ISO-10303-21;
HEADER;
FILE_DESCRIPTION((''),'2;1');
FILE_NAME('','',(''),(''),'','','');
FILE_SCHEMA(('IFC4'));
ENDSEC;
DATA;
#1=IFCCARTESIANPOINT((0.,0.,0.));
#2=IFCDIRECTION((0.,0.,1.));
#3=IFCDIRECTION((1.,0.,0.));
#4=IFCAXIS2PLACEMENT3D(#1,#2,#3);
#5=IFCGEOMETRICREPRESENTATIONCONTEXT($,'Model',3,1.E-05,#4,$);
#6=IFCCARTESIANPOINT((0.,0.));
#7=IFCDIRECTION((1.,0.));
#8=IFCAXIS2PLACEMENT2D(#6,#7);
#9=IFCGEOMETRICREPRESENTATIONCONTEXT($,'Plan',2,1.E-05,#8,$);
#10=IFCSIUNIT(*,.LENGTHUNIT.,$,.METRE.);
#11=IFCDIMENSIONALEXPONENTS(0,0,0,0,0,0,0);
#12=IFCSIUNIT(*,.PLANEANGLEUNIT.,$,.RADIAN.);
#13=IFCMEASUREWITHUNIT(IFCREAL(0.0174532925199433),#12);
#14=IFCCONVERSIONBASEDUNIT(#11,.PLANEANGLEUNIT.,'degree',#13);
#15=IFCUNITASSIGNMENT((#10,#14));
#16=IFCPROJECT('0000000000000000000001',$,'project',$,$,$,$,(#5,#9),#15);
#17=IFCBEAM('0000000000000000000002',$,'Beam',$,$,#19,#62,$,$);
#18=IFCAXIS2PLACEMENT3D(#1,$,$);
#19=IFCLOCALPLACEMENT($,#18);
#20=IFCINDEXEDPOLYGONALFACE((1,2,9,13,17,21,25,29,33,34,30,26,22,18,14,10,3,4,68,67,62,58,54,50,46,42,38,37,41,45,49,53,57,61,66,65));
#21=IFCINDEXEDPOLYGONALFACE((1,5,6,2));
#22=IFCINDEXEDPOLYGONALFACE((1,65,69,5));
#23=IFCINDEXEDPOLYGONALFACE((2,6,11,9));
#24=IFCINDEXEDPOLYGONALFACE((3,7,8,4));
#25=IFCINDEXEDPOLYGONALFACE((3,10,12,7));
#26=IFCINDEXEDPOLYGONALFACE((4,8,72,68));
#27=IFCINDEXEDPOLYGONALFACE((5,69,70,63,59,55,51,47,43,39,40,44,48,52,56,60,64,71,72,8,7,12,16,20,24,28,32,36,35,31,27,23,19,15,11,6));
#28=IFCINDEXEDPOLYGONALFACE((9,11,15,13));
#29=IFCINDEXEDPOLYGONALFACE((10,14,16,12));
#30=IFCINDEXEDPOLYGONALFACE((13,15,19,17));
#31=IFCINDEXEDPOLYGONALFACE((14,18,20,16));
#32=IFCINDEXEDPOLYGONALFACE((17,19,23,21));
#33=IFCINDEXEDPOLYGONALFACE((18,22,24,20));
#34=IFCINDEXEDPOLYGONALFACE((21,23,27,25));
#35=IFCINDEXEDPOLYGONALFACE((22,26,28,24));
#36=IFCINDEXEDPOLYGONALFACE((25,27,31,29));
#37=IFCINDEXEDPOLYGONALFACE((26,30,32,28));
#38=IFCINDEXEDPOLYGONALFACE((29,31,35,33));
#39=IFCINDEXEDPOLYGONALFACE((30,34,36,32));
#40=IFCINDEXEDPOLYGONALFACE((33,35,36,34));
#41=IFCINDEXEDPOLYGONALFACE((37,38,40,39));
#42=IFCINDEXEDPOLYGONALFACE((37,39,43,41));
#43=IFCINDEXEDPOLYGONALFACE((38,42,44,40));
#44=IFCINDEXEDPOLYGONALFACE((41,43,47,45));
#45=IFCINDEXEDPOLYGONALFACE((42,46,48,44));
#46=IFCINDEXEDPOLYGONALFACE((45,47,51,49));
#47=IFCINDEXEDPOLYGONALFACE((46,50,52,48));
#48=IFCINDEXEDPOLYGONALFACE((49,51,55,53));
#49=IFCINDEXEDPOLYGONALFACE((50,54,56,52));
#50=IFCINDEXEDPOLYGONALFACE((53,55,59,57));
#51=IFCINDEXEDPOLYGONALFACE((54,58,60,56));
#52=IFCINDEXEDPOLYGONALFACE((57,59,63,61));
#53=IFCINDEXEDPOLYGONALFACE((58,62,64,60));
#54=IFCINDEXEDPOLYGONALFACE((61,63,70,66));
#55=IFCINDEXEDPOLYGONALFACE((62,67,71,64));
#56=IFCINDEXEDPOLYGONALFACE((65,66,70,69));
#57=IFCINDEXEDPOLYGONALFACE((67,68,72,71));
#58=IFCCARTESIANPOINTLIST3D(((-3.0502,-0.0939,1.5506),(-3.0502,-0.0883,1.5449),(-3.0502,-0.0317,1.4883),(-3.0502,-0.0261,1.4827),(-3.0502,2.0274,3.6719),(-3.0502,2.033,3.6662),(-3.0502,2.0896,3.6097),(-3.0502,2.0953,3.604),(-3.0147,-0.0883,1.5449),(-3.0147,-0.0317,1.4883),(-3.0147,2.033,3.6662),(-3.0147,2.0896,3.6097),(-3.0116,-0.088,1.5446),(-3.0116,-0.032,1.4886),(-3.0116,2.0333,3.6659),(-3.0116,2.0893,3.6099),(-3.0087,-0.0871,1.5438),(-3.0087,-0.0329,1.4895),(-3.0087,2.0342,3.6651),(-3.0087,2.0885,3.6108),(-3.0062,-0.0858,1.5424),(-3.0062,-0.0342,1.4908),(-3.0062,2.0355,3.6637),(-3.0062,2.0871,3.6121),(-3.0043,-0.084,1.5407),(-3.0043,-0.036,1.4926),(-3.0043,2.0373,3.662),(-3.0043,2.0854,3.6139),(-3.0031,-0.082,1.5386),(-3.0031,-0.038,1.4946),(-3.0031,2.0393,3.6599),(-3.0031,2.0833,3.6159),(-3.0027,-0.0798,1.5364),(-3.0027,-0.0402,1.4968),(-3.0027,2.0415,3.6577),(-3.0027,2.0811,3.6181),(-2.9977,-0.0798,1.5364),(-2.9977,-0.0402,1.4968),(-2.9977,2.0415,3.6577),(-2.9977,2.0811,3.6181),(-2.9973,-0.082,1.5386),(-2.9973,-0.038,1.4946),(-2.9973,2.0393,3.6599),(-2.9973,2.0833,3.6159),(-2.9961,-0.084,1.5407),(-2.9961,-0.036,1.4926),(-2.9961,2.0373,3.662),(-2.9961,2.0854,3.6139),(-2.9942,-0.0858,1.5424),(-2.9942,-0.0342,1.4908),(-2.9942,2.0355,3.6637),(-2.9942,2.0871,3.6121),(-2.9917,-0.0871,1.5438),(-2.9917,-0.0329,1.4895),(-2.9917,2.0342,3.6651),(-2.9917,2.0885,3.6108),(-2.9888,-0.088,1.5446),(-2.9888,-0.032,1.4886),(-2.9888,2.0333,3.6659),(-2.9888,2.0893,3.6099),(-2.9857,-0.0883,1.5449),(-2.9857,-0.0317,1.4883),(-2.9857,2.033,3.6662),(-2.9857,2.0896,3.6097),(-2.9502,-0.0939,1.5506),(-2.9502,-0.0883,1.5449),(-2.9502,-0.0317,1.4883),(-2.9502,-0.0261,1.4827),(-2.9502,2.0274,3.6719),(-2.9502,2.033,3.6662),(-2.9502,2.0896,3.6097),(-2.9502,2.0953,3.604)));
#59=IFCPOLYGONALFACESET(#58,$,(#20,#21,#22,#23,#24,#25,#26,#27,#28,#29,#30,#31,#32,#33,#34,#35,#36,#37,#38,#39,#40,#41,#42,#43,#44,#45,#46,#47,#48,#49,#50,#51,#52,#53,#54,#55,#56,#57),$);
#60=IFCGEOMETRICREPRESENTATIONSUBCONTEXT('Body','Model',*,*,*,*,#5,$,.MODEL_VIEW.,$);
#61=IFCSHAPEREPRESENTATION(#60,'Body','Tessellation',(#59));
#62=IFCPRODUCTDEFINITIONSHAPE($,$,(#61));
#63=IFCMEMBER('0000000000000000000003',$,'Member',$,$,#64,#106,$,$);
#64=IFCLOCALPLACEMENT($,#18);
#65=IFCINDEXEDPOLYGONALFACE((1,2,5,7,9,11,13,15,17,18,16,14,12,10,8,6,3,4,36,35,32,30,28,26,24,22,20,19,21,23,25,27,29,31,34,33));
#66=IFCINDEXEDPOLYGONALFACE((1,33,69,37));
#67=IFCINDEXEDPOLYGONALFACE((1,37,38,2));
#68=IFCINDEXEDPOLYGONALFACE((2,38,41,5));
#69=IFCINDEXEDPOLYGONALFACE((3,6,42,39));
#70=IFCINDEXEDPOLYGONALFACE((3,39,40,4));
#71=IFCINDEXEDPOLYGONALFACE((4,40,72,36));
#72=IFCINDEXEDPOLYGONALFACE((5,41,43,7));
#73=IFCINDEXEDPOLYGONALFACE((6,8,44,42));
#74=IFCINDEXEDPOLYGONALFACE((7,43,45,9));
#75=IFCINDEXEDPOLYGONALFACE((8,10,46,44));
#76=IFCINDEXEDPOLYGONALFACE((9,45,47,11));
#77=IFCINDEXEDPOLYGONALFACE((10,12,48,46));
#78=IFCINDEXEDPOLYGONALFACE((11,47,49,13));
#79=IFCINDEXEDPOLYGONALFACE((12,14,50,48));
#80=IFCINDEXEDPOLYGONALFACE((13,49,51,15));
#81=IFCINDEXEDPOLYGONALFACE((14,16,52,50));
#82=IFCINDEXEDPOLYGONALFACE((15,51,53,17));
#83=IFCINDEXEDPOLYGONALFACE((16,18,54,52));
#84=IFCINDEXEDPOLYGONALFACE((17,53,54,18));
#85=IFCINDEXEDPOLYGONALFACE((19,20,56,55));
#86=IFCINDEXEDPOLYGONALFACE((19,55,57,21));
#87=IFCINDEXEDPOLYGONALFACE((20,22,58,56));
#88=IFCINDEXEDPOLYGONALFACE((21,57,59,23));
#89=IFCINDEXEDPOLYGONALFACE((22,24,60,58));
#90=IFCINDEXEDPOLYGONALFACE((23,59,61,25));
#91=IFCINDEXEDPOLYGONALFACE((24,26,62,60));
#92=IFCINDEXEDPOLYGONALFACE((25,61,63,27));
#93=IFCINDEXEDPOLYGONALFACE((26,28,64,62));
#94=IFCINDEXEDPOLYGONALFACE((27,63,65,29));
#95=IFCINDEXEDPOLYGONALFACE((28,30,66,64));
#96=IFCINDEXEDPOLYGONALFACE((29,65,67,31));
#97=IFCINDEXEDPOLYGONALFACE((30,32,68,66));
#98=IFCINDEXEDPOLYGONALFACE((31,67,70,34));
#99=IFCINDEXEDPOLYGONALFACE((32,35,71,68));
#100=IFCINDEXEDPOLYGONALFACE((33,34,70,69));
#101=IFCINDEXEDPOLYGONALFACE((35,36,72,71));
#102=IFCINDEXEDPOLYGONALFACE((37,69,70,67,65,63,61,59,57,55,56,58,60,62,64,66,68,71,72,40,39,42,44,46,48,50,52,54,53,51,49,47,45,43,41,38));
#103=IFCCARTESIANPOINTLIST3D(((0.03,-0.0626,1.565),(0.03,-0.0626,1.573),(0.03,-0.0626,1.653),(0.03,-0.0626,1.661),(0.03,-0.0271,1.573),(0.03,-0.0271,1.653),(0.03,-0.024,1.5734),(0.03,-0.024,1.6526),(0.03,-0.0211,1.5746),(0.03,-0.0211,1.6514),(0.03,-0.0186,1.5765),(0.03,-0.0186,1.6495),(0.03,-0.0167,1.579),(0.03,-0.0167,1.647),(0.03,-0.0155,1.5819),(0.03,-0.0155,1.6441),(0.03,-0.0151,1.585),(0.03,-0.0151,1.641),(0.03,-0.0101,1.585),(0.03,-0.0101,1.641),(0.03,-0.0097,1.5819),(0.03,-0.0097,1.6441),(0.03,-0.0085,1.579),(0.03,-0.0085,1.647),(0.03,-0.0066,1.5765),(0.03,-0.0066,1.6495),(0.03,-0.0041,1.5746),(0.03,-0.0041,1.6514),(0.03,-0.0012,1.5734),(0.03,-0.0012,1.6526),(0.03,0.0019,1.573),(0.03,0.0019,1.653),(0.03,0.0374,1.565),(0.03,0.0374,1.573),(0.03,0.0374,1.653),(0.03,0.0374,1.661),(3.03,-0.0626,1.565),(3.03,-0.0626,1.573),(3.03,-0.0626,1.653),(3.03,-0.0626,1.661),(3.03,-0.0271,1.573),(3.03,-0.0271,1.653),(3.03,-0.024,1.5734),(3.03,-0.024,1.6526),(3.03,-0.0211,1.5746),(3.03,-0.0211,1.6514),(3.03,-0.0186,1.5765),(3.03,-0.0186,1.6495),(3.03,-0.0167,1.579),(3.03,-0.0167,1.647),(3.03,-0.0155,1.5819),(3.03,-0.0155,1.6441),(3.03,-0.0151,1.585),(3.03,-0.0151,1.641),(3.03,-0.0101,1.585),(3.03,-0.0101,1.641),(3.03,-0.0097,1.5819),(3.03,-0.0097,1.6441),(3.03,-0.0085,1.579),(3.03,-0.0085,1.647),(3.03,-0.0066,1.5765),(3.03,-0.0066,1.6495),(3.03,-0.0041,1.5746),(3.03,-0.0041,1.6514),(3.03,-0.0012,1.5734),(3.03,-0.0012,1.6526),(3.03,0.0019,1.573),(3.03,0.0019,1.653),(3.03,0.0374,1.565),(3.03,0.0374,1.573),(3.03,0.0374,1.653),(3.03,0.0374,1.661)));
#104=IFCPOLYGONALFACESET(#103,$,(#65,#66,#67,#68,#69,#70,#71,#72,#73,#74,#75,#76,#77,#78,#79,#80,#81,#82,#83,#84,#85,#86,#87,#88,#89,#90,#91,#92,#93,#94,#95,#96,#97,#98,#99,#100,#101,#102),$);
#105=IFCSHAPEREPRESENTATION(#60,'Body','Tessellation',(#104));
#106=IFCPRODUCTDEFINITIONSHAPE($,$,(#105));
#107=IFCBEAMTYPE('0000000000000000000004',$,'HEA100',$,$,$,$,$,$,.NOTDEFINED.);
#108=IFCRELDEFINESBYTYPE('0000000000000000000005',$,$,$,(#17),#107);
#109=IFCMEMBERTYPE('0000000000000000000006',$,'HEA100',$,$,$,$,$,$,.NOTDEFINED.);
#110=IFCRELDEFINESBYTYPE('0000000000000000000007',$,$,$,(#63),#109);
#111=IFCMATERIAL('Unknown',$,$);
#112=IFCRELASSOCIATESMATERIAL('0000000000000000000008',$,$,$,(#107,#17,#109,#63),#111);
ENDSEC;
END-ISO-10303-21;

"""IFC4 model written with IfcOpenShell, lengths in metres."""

from ifc_helpers import new_model, entity, si_unit, converted_unit, frame, origin_with_axes, origin_2d_with_axis, place, context, subcontext, project, i_section, extrude, material, material_profile, profile_set, profile_usage, type_object, element, save


model = new_model("IFC4")

# Units and contexts
model_context = context("Model", 3, precision=1e-05, world=origin_with_axes())
plan_context = context("Plan", 2, precision=1e-05, world=origin_2d_with_axis())
body_context = subcontext(model_context, "Body", "Model", "MODEL_VIEW")
ifc_project = project(units=[si_unit("LENGTHUNIT", "METRE"), converted_unit("PLANEANGLEUNIT", "degree", entity("IfcReal", 0.0174532925199433), si_unit("PLANEANGLEUNIT", "RADIAN"), dimensions=[0, 0, 0, 0, 0, 0, 0])], contexts=[model_context, plan_context])

# Shared definitions
ifc_material = material(Name="Unknown")

# Beam
ifc_material_profile_1 = material_profile(ifc_material, i_section(OverallWidth=0.1, OverallDepth=0.096, WebThickness=0.005, FlangeThickness=0.008, FilletRadius=0.012))
ifc_profile_set_1 = profile_set([ifc_material_profile_1])
beam_type = type_object("IfcBeamType", Name="HEA100", PredefinedType="NOTDEFINED", material=ifc_profile_set_1)
ifc_profile_usage_1 = profile_usage(ifc_profile_set_1, cardinal=5)
beam_1_placement = place(None, frame((-3.0002, -0.06, 1.5166), z_axis=(0.0, 0.707107, 0.707107), x_axis=(1.0, 0.0, 0.0)))
element("IfcBeam", 1, at=beam_1_placement, type_object=beam_type, material=ifc_profile_usage_1, Name="Beam", context=body_context, shape_type="SweptSolid", body=[
    extrude(i_section(OverallWidth=0.1, OverallDepth=0.096, WebThickness=0.005, FlangeThickness=0.008, FilletRadius=0.012), origin_with_axes(), (0.0, 0.0, 1.0), 3.0),
])

# Member
ifc_material_profile_2 = material_profile(ifc_material, i_section(OverallWidth=0.1, OverallDepth=0.096, WebThickness=0.005, FlangeThickness=0.008, FilletRadius=0.012))
ifc_profile_set_2 = profile_set([ifc_material_profile_2])
ifc_profile_usage_2 = profile_usage(ifc_profile_set_2, cardinal=5)
member_type = type_object("IfcMemberType", Name="HEA100", PredefinedType="NOTDEFINED", material=ifc_profile_set_2)
member_placement = place(None, frame((0.03, -0.0126, 1.613), z_axis=(1.0, 0.0, 0.0), x_axis=(0.0, 1.0, 0.0)))
element("IfcMember", 2, at=member_placement, type_object=member_type, material=ifc_profile_usage_2, Name="Member", context=body_context, shape_type="SweptSolid", body=[
    extrude(i_section(OverallWidth=0.1, OverallDepth=0.096, WebThickness=0.005, FlangeThickness=0.008, FilletRadius=0.012), origin_with_axes(), (0.0, 0.0, 1.0), 3.0),
])

save(model, "model.ifc")
